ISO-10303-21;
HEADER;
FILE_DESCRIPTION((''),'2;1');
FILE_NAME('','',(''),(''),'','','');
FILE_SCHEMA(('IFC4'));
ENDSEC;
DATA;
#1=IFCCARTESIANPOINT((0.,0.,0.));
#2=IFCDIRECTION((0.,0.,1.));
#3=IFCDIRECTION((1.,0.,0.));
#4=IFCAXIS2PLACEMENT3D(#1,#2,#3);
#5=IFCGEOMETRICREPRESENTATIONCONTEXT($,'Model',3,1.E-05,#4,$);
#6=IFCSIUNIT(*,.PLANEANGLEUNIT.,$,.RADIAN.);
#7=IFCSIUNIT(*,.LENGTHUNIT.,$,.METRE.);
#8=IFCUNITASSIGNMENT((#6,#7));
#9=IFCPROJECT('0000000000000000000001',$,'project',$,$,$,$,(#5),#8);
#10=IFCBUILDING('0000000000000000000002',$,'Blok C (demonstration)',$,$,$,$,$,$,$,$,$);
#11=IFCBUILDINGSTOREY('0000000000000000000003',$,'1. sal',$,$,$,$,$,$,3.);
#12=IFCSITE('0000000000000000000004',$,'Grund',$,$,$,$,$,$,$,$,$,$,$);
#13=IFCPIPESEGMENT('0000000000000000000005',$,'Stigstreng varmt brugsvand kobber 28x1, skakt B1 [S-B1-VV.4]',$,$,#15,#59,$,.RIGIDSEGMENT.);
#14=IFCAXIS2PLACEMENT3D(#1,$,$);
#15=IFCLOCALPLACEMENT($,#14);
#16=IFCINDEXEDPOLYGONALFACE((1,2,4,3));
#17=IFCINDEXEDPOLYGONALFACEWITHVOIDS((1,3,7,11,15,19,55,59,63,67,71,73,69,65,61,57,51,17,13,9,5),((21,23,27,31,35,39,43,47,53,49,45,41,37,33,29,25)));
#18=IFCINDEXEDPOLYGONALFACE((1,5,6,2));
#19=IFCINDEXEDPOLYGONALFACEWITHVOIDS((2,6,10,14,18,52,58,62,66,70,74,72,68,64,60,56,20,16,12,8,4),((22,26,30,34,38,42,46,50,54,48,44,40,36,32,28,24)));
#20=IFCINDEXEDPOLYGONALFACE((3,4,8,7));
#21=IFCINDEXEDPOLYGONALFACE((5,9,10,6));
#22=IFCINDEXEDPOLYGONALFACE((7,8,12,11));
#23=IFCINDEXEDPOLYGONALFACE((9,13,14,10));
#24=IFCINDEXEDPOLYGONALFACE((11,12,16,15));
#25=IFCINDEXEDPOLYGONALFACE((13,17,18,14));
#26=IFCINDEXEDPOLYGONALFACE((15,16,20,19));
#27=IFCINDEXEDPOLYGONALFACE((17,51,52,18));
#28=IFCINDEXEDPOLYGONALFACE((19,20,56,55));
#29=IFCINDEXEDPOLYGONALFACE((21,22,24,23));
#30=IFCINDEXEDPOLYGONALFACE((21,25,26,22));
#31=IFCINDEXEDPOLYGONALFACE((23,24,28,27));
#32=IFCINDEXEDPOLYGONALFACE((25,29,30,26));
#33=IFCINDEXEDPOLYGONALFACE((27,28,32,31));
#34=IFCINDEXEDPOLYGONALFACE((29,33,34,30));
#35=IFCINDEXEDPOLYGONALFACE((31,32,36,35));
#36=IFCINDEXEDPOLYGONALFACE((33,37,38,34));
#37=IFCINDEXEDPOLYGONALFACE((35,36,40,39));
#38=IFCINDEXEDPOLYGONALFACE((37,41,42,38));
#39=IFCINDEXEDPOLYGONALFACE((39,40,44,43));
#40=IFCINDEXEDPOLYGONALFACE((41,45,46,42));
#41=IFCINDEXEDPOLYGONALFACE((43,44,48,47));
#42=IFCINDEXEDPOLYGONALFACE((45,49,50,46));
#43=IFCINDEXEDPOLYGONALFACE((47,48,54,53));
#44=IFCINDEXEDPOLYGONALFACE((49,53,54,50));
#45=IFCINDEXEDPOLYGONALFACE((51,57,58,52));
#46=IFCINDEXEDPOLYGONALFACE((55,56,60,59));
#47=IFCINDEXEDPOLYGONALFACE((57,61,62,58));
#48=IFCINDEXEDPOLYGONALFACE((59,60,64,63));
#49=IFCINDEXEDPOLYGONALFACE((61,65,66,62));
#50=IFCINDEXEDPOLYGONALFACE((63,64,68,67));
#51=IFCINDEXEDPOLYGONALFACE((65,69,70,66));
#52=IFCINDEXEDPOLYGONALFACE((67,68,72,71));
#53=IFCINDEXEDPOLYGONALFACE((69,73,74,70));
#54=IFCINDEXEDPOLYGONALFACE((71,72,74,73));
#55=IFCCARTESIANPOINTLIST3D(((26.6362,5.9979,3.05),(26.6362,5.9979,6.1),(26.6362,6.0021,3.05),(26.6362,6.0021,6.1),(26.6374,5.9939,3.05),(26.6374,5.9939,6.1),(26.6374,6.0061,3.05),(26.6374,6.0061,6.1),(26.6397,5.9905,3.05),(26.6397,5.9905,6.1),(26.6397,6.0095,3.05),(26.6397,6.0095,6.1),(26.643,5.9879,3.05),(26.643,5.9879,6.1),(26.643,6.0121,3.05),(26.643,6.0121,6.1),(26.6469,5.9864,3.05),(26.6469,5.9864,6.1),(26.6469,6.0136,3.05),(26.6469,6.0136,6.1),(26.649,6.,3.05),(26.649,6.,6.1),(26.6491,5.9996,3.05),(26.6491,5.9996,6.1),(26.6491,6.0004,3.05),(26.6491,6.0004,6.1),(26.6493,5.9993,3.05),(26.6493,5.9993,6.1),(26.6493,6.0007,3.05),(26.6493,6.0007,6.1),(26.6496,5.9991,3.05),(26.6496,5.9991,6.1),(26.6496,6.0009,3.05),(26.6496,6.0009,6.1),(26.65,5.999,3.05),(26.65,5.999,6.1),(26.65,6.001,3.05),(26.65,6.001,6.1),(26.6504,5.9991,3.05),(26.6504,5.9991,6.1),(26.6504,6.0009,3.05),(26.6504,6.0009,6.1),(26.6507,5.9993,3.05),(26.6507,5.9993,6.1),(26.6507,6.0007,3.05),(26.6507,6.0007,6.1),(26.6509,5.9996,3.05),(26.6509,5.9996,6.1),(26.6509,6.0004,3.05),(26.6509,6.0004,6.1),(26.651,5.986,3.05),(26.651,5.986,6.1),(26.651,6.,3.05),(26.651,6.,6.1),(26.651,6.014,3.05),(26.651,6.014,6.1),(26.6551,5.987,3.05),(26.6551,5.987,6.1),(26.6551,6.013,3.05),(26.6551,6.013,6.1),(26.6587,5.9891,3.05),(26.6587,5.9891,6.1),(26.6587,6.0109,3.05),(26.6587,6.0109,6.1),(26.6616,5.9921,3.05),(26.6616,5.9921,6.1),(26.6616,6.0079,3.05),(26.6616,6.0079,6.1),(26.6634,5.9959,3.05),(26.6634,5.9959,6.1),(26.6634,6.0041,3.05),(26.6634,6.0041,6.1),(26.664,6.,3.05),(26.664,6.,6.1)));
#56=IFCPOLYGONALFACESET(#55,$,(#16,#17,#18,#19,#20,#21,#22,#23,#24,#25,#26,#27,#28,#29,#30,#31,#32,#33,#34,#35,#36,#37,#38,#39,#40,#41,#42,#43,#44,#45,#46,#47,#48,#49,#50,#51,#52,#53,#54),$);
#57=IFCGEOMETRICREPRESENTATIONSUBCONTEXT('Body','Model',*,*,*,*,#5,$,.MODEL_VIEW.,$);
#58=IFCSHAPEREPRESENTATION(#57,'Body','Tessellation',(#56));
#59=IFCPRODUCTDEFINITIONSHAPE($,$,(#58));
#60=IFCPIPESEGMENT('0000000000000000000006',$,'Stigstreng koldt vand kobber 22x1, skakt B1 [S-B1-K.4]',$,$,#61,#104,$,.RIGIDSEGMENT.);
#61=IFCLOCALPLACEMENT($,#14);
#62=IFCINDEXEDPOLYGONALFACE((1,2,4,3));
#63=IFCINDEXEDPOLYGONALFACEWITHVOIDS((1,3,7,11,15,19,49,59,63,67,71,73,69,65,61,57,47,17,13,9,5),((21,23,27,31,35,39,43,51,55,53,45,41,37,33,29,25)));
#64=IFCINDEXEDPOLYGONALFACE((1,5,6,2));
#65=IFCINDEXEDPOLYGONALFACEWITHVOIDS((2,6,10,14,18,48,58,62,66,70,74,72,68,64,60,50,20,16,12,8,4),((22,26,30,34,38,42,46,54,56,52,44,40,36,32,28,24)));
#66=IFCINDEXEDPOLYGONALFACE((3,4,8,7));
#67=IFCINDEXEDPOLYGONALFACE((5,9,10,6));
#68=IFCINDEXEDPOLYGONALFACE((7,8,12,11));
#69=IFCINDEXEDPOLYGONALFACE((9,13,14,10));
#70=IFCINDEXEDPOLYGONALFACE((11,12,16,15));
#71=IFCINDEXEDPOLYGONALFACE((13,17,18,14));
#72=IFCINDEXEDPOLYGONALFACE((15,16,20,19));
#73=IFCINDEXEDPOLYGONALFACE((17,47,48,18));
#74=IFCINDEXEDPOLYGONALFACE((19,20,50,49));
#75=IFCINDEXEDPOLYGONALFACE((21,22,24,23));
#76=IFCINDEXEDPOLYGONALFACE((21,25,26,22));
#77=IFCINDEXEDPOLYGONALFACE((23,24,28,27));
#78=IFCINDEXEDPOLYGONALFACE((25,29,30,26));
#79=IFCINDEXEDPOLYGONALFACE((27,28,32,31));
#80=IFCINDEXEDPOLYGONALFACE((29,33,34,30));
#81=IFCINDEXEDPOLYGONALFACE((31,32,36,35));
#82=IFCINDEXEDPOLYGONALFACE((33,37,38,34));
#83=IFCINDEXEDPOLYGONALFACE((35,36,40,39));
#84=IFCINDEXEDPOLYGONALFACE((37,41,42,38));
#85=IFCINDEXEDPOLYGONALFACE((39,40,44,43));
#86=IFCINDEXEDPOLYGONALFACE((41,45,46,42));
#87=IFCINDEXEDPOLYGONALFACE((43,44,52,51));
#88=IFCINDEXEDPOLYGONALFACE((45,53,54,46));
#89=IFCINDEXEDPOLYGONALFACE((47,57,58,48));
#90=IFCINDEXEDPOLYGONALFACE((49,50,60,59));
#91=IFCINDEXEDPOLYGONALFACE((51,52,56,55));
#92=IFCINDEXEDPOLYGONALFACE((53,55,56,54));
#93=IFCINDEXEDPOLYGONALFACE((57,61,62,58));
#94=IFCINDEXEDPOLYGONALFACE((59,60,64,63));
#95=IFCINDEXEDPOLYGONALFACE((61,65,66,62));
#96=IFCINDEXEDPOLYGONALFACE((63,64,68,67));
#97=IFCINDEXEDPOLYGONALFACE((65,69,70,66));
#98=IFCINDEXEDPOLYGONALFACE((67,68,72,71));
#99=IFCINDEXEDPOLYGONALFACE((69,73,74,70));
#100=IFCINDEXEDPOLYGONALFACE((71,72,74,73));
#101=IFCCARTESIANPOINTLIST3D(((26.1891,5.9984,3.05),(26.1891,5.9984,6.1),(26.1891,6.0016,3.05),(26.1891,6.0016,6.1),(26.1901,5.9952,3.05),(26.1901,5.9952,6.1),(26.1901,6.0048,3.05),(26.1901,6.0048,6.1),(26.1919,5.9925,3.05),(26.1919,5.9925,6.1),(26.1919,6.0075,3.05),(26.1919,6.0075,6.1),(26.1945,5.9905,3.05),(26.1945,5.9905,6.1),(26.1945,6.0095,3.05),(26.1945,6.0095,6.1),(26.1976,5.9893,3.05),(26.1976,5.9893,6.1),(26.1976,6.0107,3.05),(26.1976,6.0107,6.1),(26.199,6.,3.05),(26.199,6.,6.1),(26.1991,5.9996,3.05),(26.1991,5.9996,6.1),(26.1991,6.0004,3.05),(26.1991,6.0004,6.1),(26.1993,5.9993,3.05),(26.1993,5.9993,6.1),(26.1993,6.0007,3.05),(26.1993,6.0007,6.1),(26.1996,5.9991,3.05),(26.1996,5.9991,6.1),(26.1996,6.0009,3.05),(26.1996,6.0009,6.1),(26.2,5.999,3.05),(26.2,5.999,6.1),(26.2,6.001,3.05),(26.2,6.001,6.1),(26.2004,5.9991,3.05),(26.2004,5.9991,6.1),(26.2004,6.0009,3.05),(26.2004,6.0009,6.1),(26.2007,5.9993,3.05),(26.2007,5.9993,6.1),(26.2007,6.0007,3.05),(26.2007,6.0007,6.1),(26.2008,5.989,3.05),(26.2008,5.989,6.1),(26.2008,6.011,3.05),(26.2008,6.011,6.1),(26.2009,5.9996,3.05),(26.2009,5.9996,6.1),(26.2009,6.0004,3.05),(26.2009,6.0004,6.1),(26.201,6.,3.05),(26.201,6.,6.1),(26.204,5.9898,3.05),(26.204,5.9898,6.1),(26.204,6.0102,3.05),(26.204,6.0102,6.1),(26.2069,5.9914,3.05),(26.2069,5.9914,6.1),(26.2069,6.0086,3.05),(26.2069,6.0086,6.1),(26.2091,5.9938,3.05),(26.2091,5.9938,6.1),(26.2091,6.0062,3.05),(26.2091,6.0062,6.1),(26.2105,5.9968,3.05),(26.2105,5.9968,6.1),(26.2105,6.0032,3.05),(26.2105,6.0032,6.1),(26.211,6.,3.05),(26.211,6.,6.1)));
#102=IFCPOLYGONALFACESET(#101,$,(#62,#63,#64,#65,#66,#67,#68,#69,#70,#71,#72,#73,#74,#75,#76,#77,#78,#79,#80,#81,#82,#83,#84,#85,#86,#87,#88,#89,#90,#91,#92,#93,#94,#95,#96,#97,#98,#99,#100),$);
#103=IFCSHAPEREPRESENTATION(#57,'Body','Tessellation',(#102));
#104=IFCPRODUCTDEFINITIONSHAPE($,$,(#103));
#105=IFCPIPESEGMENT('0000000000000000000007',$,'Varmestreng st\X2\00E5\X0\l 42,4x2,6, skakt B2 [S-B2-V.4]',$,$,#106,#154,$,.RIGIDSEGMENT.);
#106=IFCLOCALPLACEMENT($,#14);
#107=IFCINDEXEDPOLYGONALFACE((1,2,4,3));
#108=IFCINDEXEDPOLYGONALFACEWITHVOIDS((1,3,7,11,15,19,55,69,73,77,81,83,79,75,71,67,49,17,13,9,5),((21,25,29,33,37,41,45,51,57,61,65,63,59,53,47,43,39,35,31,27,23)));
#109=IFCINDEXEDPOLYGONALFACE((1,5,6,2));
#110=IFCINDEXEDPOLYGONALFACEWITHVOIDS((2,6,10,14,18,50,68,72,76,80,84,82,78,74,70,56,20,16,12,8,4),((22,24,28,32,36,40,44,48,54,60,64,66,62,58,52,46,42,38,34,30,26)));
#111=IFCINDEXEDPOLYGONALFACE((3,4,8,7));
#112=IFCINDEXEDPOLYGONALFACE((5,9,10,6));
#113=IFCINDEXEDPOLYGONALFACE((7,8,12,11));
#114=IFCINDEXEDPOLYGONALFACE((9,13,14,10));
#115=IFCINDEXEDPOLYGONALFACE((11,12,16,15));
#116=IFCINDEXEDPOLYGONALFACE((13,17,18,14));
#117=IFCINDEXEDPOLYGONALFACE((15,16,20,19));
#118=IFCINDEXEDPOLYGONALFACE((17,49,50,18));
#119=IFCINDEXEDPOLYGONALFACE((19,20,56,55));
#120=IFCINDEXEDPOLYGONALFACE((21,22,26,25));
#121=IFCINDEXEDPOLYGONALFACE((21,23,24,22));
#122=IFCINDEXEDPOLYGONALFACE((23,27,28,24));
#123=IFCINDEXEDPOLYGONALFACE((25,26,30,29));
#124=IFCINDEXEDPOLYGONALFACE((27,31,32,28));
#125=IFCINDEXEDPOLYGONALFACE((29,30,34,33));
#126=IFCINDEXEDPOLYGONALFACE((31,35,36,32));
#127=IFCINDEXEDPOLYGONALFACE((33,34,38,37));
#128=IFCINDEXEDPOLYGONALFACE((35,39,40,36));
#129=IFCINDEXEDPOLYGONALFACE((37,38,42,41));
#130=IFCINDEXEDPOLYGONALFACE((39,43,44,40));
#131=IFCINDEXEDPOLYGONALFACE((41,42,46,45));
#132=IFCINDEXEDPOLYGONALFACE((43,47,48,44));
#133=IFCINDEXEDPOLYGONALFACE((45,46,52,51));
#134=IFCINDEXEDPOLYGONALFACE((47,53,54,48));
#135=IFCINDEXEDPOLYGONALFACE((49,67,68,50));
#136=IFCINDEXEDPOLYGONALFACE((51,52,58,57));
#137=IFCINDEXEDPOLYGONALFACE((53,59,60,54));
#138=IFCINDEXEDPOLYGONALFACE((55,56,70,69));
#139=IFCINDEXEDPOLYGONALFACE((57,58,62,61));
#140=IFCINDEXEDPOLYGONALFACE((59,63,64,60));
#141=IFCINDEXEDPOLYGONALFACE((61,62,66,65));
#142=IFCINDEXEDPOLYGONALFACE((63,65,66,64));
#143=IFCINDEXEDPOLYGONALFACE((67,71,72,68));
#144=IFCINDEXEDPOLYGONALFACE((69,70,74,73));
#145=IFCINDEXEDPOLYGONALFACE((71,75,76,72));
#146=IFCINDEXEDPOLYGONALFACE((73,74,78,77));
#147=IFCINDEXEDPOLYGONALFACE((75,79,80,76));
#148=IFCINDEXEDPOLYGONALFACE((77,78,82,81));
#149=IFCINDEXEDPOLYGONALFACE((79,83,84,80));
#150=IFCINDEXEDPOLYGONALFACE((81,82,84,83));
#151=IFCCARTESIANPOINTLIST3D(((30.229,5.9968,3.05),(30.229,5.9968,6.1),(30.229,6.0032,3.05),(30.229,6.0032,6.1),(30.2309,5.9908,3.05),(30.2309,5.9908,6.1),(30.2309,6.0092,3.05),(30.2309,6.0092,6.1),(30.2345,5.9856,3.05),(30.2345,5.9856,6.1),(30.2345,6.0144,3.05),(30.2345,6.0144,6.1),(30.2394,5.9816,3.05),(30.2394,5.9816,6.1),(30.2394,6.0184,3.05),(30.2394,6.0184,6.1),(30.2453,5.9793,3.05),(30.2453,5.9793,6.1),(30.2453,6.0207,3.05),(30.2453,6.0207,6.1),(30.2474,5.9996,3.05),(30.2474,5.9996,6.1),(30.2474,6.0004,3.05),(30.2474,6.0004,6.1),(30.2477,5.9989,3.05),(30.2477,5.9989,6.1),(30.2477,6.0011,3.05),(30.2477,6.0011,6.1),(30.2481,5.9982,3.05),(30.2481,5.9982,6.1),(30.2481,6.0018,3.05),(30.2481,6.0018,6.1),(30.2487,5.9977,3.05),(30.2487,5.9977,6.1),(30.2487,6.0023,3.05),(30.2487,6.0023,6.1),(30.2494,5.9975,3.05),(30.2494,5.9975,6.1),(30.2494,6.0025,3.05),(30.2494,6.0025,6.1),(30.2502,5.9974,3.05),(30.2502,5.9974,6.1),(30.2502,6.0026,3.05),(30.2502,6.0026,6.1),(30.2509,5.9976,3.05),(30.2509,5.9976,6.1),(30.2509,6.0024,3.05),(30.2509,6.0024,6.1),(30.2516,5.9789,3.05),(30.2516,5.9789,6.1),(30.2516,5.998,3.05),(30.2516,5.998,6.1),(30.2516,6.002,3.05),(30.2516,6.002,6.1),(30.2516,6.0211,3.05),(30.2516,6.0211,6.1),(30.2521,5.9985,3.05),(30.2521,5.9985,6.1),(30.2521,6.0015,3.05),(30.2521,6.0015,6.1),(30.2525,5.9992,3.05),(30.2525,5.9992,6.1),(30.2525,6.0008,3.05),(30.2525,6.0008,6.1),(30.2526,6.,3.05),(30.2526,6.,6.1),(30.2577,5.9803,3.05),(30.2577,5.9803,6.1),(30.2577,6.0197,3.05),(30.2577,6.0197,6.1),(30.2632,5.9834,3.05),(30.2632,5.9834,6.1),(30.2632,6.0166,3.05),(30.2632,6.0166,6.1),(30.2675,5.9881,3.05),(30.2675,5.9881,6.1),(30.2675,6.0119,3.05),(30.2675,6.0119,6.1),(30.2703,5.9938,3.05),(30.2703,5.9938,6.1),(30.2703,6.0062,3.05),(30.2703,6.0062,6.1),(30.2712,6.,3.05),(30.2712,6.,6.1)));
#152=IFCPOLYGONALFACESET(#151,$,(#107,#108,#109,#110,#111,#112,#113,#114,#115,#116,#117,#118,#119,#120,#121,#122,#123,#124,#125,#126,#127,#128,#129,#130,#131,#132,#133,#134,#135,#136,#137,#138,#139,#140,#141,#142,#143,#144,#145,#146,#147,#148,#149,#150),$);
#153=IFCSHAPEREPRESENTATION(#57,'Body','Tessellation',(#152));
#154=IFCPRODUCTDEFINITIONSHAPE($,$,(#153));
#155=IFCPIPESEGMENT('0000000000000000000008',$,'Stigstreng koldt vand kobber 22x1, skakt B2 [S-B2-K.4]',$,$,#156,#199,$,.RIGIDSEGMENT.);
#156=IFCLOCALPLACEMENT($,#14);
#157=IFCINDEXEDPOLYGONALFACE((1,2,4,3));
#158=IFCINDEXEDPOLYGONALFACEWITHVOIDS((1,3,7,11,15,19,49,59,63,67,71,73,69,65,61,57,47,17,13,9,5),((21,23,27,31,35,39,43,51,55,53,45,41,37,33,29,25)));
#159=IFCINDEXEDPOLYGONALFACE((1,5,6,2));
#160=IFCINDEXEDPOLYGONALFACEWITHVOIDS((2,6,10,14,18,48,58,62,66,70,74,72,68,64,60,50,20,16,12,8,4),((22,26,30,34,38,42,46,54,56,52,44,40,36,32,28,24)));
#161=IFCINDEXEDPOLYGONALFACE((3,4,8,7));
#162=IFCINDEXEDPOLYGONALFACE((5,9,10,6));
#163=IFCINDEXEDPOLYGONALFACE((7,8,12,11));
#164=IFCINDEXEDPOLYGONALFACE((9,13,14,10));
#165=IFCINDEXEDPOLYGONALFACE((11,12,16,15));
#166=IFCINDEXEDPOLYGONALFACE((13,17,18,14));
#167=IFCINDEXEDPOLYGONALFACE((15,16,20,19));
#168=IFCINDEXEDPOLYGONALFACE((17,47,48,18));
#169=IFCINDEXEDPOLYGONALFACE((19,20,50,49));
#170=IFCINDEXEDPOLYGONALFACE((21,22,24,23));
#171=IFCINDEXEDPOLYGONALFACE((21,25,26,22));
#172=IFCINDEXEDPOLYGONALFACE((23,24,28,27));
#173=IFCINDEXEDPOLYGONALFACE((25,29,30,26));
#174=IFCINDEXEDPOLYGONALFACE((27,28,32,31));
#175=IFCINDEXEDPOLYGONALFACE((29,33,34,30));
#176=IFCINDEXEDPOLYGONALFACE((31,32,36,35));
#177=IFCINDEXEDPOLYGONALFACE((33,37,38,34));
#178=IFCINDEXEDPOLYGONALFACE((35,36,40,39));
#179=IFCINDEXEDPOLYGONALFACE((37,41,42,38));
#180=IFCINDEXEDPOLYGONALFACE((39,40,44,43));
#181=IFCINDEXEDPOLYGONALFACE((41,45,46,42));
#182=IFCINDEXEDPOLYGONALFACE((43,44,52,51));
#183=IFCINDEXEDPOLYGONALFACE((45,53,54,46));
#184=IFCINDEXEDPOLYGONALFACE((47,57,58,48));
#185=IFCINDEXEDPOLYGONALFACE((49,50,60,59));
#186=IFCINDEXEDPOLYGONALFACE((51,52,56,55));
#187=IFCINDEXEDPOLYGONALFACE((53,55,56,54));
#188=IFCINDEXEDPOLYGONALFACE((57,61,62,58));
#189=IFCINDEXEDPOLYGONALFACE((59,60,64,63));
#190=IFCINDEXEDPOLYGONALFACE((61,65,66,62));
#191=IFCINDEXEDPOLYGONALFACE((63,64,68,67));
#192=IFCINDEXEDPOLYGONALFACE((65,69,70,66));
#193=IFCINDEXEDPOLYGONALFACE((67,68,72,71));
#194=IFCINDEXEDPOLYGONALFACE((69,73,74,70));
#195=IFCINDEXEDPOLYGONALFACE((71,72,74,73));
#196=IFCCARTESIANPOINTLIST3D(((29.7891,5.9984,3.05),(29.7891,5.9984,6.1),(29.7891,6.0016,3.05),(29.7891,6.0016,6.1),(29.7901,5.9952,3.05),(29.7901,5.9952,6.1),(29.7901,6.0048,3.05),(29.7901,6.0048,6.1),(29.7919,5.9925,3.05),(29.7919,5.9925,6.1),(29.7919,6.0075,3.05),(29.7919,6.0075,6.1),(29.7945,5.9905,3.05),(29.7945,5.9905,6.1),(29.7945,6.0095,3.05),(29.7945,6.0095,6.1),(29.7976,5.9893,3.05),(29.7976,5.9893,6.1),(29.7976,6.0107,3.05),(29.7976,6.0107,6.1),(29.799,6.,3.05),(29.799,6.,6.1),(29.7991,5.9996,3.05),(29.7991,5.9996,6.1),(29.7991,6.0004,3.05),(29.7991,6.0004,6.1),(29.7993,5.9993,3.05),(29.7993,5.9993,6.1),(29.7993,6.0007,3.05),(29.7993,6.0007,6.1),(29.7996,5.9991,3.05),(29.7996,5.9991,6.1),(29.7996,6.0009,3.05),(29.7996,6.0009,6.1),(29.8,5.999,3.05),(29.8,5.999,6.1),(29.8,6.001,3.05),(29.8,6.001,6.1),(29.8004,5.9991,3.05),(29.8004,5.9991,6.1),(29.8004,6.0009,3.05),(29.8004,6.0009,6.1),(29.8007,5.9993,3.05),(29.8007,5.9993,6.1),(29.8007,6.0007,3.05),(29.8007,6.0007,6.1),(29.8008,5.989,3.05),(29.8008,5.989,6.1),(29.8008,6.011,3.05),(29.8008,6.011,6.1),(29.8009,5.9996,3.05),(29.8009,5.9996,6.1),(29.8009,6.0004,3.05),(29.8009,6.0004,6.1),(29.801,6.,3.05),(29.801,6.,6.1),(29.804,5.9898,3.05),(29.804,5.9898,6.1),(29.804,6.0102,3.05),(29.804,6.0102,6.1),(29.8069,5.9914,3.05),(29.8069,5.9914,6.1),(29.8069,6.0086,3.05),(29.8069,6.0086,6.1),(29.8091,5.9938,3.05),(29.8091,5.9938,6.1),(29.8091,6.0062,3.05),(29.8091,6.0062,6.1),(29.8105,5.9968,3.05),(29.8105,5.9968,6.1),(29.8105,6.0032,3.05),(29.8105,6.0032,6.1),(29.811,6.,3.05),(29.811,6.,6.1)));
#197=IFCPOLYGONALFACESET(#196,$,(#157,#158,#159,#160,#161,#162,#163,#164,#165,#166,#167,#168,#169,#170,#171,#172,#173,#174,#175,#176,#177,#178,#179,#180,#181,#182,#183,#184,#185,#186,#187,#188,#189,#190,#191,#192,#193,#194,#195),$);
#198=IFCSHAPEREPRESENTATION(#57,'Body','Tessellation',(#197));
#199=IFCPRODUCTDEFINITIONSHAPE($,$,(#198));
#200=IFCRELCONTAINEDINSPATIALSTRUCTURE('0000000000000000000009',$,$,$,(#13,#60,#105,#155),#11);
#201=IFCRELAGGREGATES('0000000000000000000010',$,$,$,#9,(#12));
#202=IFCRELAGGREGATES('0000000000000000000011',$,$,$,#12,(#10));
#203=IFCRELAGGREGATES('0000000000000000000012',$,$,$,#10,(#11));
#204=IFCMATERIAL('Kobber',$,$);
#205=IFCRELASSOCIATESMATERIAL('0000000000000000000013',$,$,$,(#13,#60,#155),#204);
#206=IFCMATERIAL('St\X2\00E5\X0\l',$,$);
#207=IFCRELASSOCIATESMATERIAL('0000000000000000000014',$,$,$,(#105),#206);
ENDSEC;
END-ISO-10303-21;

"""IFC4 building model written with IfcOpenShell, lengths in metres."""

from ifc_helpers import new_model, si_unit, frame, origin_with_axes, place, context, subcontext, project, spatial, hollow_circle, extrude, material, element, save


model = new_model("IFC4")

# Units and contexts
model_context = context("Model", 3, precision=1e-05, world=origin_with_axes())
body_context = subcontext(model_context, "Body", "Model", "MODEL_VIEW")
ifc_project = project(units=[si_unit("PLANEANGLEUNIT", "RADIAN"), si_unit("LENGTHUNIT", "METRE")], contexts=[model_context])

# Site, building, storey
site = spatial("IfcSite", under=ifc_project, Name="Grund")
building = spatial("IfcBuilding", under=site, Name="Blok C (demonstration)")
storey = spatial("IfcBuildingStorey", under=building, Name="1. sal", Elevation=3.0)

# Pipe segments
ifc_material_1 = material(Name="Stål")
ifc_material_2 = material(Name="Kobber")
pipe_segment_1_placement = place(None, origin_with_axes())
element("IfcPipeSegment", 1, at=pipe_segment_1_placement, inside=storey, material=ifc_material_2, Name="Stigstreng varmt brugsvand kobber 28x1, skakt B1 [S-B1-VV.4]", PredefinedType="RIGIDSEGMENT", context=body_context, shape_type="SweptSolid", body=[
    extrude(hollow_circle(Radius=0.014, WallThickness=0.013), frame((26.65, 6.0, 3.05), z_axis=(0.0, 0.0, 1.0), x_axis=(1.0, 0.0, 0.0)), (0.0, 0.0, 1.0), 3.05),
])
pipe_segment_2_placement = place(None, origin_with_axes())
element("IfcPipeSegment", 2, at=pipe_segment_2_placement, inside=storey, material=ifc_material_2, Name="Stigstreng koldt vand kobber 22x1, skakt B1 [S-B1-K.4]", PredefinedType="RIGIDSEGMENT", context=body_context, shape_type="SweptSolid", body=[
    extrude(hollow_circle(Radius=0.011, WallThickness=0.01), frame((26.2, 6.0, 3.05), z_axis=(0.0, 0.0, 1.0), x_axis=(1.0, 0.0, 0.0)), (0.0, 0.0, 1.0), 3.05),
])
pipe_segment_3_placement = place(None, origin_with_axes())
element("IfcPipeSegment", 3, at=pipe_segment_3_placement, inside=storey, material=ifc_material_1, Name="Varmestreng stål 42,4x2,6, skakt B2 [S-B2-V.4]", PredefinedType="RIGIDSEGMENT", context=body_context, shape_type="SweptSolid", body=[
    extrude(hollow_circle(Radius=0.0212, WallThickness=0.0186), frame((30.25, 6.0, 3.05), z_axis=(0.0, 0.0, 1.0), x_axis=(1.0, 0.0, 0.0)), (0.0, 0.0, 1.0), 3.05),
])
pipe_segment_4_placement = place(None, origin_with_axes())
element("IfcPipeSegment", 4, at=pipe_segment_4_placement, inside=storey, material=ifc_material_2, Name="Stigstreng koldt vand kobber 22x1, skakt B2 [S-B2-K.4]", PredefinedType="RIGIDSEGMENT", context=body_context, shape_type="SweptSolid", body=[
    extrude(hollow_circle(Radius=0.011, WallThickness=0.01), frame((29.8, 6.0, 3.05), z_axis=(0.0, 0.0, 1.0), x_axis=(1.0, 0.0, 0.0)), (0.0, 0.0, 1.0), 3.05),
])

save(model, "model.ifc")
